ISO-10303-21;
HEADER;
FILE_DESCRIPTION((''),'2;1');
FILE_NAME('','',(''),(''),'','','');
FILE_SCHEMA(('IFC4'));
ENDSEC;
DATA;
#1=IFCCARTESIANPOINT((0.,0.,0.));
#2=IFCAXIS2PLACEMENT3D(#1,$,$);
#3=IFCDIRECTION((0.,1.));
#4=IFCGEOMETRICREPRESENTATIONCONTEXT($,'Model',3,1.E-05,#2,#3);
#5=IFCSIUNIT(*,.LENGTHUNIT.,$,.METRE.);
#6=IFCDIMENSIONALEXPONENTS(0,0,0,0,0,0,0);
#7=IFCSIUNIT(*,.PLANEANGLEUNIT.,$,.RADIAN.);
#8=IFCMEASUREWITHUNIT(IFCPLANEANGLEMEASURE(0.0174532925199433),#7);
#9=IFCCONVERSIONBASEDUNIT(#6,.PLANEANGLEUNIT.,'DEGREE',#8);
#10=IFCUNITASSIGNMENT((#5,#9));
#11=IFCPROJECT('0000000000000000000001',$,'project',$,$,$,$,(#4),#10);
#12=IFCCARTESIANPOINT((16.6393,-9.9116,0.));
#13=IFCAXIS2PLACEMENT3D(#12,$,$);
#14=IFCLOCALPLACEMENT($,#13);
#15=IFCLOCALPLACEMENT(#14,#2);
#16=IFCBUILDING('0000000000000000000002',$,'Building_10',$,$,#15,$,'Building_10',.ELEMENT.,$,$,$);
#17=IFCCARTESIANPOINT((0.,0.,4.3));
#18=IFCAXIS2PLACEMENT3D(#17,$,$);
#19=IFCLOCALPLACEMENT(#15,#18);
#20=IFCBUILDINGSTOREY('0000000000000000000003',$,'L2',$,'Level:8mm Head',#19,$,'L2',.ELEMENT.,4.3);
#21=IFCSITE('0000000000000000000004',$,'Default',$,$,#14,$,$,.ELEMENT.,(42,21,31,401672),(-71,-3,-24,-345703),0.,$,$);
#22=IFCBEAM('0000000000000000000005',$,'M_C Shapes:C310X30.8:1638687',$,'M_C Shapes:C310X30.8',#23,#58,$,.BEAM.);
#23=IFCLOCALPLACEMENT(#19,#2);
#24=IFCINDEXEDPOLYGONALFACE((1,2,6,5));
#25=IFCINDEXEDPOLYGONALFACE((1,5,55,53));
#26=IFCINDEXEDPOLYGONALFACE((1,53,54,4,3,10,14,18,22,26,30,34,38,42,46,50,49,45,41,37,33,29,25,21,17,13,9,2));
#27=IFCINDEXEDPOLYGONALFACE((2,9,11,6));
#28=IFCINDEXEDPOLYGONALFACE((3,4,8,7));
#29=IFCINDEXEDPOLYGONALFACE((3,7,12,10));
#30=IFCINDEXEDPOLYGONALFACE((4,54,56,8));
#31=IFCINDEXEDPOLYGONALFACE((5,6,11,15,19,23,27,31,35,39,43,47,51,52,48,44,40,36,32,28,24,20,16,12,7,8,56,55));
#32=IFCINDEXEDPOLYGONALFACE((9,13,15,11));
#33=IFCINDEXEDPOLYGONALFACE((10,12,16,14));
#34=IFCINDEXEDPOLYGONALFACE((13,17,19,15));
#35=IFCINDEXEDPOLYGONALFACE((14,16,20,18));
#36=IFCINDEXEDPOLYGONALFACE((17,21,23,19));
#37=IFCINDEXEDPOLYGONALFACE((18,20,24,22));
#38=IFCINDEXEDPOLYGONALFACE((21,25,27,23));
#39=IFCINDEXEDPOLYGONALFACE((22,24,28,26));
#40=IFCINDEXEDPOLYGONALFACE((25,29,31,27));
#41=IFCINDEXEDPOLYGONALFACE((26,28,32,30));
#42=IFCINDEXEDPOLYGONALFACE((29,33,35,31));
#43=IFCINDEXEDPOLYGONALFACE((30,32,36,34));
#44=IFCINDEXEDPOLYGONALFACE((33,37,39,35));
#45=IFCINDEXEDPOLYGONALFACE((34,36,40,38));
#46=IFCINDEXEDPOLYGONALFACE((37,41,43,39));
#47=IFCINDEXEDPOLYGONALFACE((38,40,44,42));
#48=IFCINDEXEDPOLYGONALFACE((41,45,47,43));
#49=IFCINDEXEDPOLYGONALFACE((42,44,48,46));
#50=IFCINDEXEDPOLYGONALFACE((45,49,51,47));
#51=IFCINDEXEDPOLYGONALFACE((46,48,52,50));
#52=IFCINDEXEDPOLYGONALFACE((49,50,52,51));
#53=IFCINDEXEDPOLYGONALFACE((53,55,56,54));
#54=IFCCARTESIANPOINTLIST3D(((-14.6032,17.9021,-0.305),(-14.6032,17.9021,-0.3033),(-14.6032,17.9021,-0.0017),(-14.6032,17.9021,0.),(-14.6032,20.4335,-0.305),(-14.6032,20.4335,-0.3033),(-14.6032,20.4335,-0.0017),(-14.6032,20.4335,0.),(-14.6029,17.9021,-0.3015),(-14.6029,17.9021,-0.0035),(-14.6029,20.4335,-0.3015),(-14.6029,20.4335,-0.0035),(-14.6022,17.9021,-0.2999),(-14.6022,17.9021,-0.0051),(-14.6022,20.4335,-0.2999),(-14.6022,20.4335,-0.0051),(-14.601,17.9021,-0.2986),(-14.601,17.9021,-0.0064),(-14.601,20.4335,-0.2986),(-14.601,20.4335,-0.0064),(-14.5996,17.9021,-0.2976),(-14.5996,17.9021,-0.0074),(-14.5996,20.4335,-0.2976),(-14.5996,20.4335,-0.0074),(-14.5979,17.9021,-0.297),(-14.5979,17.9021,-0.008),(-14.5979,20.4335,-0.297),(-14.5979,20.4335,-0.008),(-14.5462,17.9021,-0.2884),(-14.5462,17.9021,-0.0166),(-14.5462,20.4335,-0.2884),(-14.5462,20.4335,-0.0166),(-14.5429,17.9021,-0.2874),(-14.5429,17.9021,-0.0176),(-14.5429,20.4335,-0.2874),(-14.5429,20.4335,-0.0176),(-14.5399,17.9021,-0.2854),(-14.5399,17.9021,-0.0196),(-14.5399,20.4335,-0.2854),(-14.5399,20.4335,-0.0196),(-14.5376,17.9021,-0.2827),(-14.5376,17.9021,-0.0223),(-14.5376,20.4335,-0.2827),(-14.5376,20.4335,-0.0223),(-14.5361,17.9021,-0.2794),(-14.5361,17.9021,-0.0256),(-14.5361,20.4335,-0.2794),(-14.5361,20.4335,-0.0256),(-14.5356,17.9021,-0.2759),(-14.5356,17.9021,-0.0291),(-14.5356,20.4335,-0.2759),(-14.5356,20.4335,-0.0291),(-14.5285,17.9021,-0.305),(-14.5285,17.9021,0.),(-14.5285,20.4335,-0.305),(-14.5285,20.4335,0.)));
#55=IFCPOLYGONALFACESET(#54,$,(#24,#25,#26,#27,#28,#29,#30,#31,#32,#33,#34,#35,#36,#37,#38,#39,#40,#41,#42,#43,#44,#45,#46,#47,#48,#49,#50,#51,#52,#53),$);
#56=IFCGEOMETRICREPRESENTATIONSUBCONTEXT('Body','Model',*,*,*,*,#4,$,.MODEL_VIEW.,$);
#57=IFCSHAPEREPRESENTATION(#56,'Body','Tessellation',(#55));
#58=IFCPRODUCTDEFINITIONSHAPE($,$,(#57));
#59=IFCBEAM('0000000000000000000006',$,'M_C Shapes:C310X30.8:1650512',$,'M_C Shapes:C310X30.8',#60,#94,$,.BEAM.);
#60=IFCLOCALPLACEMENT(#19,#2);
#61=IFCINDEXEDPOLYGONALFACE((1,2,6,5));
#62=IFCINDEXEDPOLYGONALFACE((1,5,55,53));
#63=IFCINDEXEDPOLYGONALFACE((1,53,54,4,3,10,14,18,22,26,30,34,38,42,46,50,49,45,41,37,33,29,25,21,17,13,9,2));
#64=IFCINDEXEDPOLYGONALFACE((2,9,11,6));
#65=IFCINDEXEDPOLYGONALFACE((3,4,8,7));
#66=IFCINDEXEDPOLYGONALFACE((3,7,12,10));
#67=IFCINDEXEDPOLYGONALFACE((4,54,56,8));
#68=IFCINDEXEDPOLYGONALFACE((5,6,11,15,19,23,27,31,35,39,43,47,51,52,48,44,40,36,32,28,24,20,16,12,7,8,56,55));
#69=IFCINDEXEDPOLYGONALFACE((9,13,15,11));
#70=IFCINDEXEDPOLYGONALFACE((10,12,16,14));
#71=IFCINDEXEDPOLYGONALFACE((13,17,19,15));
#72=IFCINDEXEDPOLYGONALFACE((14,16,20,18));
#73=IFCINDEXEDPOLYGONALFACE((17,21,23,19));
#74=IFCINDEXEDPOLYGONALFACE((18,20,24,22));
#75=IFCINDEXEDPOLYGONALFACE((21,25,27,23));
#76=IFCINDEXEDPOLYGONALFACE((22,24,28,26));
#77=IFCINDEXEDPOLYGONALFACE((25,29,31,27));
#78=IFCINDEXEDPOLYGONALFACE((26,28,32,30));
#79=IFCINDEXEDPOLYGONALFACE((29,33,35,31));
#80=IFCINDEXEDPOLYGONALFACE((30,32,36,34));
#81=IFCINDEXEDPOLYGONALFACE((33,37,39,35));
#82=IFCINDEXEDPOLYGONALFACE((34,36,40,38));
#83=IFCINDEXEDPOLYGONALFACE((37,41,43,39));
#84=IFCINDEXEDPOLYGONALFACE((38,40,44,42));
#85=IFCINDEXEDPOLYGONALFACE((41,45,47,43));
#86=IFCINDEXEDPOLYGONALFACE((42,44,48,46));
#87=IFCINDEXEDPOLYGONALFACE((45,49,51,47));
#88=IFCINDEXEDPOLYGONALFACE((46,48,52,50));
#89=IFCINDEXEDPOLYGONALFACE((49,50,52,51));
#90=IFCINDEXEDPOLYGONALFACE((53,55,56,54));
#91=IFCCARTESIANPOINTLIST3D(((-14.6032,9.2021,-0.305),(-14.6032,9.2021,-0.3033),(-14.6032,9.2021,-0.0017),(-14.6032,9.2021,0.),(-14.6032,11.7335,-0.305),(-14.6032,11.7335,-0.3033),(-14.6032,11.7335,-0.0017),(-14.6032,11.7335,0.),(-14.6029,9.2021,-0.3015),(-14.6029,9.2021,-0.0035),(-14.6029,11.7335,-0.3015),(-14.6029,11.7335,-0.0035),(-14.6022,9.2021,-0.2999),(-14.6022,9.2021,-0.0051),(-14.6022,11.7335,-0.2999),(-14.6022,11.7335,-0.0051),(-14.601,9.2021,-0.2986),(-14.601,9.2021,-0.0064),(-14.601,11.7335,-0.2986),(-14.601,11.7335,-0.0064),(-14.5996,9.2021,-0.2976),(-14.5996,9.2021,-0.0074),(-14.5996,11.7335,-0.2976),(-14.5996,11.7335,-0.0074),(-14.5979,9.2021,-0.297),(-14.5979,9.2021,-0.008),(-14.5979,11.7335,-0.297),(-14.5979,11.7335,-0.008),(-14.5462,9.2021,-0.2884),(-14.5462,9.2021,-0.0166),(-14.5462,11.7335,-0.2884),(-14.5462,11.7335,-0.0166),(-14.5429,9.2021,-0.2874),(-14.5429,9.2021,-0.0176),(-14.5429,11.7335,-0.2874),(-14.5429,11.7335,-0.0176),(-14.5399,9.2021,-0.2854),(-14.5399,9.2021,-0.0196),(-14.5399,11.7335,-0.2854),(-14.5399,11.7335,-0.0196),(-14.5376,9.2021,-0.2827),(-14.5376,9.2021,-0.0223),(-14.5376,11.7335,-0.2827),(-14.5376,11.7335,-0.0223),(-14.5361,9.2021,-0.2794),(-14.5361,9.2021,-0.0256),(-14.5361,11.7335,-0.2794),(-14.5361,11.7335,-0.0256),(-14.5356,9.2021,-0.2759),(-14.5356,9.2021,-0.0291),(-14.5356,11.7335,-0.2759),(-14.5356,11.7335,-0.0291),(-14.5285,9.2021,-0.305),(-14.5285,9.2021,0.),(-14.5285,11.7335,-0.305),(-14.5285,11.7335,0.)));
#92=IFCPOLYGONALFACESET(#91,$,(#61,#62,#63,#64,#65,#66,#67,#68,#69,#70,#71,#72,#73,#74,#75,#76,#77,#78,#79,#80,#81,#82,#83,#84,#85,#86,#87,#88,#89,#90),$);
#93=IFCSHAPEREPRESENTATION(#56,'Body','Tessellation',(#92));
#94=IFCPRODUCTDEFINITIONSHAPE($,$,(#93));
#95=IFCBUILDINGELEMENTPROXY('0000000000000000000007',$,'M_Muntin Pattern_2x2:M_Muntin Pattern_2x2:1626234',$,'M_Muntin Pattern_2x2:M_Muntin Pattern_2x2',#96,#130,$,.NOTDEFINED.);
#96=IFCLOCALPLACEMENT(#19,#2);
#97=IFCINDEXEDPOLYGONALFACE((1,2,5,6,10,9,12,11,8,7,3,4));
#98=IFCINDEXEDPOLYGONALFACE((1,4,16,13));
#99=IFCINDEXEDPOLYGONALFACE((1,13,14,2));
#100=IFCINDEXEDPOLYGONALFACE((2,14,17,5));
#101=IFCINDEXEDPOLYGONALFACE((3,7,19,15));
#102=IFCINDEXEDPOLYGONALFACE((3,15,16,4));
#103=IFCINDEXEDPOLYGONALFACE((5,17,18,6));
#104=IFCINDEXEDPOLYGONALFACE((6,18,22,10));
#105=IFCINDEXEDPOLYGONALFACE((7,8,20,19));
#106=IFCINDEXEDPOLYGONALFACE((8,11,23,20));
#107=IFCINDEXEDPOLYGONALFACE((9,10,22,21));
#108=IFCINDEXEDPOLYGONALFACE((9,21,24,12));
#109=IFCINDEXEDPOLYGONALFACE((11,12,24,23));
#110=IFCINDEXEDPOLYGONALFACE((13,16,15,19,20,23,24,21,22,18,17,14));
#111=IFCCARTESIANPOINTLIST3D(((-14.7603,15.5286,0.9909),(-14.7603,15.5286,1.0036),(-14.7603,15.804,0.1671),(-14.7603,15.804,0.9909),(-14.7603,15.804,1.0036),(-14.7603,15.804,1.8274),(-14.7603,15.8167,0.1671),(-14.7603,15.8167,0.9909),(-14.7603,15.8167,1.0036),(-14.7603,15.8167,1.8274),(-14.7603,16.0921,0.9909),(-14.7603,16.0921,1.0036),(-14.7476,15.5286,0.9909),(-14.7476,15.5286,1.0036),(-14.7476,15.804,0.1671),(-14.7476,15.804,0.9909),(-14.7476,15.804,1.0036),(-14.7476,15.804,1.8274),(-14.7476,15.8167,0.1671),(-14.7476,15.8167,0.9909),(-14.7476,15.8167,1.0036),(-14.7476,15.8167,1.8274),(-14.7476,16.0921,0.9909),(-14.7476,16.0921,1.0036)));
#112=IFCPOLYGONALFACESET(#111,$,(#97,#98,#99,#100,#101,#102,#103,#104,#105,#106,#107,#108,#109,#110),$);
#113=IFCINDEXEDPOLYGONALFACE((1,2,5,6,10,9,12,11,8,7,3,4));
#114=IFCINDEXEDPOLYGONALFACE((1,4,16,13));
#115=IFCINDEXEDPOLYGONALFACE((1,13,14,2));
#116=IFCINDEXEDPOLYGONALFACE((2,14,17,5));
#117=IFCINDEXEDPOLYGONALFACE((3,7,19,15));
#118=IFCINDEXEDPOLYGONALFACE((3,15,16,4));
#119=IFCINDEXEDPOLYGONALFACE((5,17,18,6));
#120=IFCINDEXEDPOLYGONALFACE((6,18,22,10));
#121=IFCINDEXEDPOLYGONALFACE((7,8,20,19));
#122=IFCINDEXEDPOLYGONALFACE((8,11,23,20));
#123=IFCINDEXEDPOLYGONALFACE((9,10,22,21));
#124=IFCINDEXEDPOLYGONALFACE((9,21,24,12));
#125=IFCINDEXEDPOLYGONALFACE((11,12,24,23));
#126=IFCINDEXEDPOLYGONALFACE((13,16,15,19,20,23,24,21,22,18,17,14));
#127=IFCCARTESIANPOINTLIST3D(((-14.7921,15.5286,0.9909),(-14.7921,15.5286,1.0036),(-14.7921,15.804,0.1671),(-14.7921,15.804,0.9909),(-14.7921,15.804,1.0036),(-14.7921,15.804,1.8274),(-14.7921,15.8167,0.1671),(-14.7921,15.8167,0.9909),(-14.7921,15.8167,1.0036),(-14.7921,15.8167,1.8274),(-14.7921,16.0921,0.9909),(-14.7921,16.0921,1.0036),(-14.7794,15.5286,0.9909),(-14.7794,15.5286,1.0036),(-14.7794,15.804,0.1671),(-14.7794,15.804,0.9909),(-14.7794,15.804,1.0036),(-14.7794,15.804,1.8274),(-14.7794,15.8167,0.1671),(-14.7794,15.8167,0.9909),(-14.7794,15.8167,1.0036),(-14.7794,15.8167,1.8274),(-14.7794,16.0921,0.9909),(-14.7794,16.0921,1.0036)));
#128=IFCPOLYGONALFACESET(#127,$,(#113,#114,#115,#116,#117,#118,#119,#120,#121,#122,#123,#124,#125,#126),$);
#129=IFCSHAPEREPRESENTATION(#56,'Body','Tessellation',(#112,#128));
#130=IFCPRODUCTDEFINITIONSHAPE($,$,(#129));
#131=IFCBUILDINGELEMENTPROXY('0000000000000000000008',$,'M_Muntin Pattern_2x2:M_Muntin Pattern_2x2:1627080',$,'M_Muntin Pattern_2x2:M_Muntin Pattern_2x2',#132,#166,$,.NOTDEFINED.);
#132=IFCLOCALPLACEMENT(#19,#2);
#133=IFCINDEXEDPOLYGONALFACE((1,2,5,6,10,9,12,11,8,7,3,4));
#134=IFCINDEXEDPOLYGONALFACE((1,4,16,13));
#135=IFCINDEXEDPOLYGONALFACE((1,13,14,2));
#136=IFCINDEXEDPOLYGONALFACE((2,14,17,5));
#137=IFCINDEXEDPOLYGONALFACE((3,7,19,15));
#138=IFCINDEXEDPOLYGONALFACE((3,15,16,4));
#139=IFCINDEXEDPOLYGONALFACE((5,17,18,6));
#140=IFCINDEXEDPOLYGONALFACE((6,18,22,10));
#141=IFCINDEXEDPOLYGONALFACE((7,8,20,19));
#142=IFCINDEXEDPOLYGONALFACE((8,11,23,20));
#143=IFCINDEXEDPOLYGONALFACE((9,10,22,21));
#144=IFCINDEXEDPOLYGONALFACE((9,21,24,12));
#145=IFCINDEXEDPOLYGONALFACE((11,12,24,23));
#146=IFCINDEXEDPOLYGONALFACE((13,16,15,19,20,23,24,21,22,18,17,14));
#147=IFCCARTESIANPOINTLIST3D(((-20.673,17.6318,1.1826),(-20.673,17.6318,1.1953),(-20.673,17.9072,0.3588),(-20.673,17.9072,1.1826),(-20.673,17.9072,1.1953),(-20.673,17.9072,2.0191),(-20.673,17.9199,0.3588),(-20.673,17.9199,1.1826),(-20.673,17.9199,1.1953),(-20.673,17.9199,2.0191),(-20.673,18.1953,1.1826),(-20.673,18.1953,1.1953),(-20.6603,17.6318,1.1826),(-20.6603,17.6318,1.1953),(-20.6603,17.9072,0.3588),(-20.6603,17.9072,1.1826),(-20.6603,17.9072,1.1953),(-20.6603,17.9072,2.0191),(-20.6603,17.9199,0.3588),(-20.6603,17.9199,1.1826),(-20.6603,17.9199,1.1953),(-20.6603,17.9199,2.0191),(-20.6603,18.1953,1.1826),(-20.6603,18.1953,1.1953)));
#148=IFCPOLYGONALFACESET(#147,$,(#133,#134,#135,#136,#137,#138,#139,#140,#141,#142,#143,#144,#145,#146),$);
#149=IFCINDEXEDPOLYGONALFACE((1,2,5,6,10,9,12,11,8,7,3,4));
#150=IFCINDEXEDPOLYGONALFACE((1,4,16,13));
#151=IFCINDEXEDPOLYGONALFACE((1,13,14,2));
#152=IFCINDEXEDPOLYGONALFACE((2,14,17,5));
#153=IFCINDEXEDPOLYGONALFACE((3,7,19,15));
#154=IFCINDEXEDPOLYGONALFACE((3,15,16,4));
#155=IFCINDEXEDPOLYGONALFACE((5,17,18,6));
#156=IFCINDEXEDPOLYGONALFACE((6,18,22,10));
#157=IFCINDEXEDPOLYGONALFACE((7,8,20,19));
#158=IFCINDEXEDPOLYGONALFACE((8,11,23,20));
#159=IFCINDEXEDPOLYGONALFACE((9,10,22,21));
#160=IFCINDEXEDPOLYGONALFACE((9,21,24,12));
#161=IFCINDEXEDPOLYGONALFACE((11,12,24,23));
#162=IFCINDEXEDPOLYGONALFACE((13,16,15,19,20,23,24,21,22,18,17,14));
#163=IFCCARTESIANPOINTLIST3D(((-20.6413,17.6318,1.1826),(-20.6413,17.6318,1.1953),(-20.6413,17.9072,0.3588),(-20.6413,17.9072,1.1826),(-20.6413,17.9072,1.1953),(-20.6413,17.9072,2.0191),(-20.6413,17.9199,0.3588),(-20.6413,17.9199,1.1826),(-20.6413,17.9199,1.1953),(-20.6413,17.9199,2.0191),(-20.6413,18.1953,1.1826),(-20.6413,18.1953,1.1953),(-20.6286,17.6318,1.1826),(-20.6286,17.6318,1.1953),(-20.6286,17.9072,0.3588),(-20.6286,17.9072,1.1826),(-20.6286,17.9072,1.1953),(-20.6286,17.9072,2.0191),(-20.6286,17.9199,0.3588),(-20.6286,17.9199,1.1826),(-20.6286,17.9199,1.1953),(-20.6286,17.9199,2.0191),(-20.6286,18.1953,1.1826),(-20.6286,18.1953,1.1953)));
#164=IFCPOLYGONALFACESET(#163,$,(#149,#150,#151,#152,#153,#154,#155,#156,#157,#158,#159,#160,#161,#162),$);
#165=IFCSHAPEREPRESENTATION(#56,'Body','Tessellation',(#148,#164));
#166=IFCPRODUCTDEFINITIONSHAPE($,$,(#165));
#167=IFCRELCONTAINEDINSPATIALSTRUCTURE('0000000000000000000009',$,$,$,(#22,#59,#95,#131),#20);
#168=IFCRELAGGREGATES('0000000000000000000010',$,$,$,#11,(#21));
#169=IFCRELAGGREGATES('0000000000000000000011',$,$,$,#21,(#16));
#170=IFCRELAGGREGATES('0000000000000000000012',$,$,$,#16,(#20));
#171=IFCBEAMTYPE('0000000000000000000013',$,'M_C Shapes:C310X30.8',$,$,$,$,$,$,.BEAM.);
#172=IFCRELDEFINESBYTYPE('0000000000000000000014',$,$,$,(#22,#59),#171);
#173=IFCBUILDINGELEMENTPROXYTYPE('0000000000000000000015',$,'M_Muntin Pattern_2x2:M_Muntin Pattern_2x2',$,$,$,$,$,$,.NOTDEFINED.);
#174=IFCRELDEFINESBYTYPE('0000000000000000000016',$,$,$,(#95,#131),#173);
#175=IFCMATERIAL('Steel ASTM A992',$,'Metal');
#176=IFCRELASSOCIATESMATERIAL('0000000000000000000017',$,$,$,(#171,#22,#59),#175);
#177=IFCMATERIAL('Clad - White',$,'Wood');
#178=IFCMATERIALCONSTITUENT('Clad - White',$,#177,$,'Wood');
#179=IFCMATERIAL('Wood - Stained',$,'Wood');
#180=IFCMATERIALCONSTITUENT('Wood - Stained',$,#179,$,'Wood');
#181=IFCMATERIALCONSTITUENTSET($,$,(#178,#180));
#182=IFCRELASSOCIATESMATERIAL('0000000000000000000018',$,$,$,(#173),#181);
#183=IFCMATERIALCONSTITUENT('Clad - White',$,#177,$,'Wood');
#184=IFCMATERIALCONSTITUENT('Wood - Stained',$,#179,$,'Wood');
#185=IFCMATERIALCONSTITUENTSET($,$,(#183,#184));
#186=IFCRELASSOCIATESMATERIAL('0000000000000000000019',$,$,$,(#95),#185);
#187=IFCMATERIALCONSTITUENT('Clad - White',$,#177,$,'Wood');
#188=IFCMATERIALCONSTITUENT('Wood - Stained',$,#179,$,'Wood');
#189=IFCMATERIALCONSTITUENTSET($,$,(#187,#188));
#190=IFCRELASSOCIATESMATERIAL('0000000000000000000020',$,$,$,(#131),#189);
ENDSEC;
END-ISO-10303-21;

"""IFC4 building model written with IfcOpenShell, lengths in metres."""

from ifc_helpers import new_model, entity, si_unit, converted_unit, direction, frame, origin, place, context, subcontext, project, spatial, line, arc, indexed_curve, outline, extrude, source, transform, mapped, material, constituent, constituent_set, type_object, type_shapes, element, save


model = new_model("IFC4")

# Units and contexts
model_context = context("Model", 3, precision=1e-05, world=origin(), true_north=direction((0.0, 1.0)))
body_context = subcontext(model_context, "Body", "Model", "MODEL_VIEW")
ifc_project = project(units=[si_unit("LENGTHUNIT", "METRE"), converted_unit("PLANEANGLEUNIT", "DEGREE", entity("IfcPlaneAngleMeasure", 0.0174532925199433), si_unit("PLANEANGLEUNIT", "RADIAN"), dimensions=[0, 0, 0, 0, 0, 0, 0])], contexts=[model_context])

# Site, building, storey
site_placement = place(None, frame((16.6393, -9.9116, 0.0)))
site = spatial("IfcSite", under=ifc_project, at=site_placement, Name="Default", CompositionType="ELEMENT", RefLatitude=(42, 21, 31, 401672), RefLongitude=(-71, -3, -24, -345703), RefElevation=0.0)
building_placement = place(site_placement, origin())
building = spatial("IfcBuilding", under=site, at=building_placement, Name="Building_10", LongName="Building_10", CompositionType="ELEMENT")
storey_placement = place(building_placement, frame((0.0, 0.0, 4.3)))
storey = spatial("IfcBuildingStorey", under=building, at=storey_placement, Name="L2", ObjectType="Level:8mm Head", LongName="L2", CompositionType="ELEMENT", Elevation=4.3)

# Shared definitions
ifc_material_1 = material(Name="Steel ASTM A992", Category="Metal")

# Beams
beam_type_1 = type_object("IfcBeamType", Name="M_C Shapes:C310X30.8", PredefinedType="BEAM", material=ifc_material_1)
shared_shape_1 = source(origin(), body_context, "Body", "SweptSolid", [
    extrude(outline(indexed_curve([(-0.0406, -0.1525), (0.0341, -0.1525), (0.0341, -0.1508), (0.0326, -0.1467), (0.0288, -0.1445), (-0.0228, -0.1359), (-0.0305, -0.1316), (-0.0335, -0.1234), (-0.0335, 0.1234), (-0.0305, 0.1316), (-0.0228, 0.1359), (0.0288, 0.1445), (0.0326, 0.1467), (0.0341, 0.1508), (0.0341, 0.1525), (-0.0406, 0.1525)], segments=[line(1, 2, 3), arc(3, 4, 5), line(5, 6), arc(6, 7, 8), line(8, 9), arc(9, 10, 11), line(11, 12), arc(12, 13, 14), line(14, 15, 16, 1)], self_intersect=False)), frame((-1.2657, -0.0229, 0.0), z_axis=(1.0, 0.0, 0.0), x_axis=(0.0, -1.0, 0.0)), (0.0, 0.0, 1.0), 2.5314),
])
type_shapes(beam_type_1, [shared_shape_1])
for number, where, z_axis, x_axis, name in (
    (1, (-14.5462, 19.1678, -0.1525), (0.0, 0.0, 1.0), (0.0, -1.0, 0.0), "M_C Shapes:C310X30.8:1638687"),
    (2, (-14.5462, 10.4678, -0.1525), (0.0, 0.0, 1.0), (0.0, -1.0, 0.0), "M_C Shapes:C310X30.8:1650512"),
):
    element("IfcBeam", number, at=place(storey_placement, frame(where, z_axis=z_axis, x_axis=x_axis)), inside=storey, type_object=beam_type_1, material=ifc_material_1, Name=name, ObjectType="M_C Shapes:C310X30.8", PredefinedType="BEAM", context=body_context, shape_type="MappedRepresentation", body=[
        mapped(shared_shape_1, transform((0.0, 0.0, 0.0), scale=1.0)),
    ])

# Building element proxies
ifc_material_2 = material(Name="Clad - White", Category="Wood")
ifc_constituent_1 = constituent(ifc_material_2, Name="Clad - White", Category="Wood")
ifc_material_3 = material(Name="Wood - Stained", Category="Wood")
ifc_constituent_2 = constituent(ifc_material_3, Name="Wood - Stained", Category="Wood")
ifc_constituent_set_1 = constituent_set(constituents=[ifc_constituent_1, ifc_constituent_2])
ifc_constituent_3 = constituent(ifc_material_2, Name="Clad - White", Category="Wood")
ifc_constituent_4 = constituent(ifc_material_3, Name="Wood - Stained", Category="Wood")
ifc_constituent_set_2 = constituent_set(constituents=[ifc_constituent_3, ifc_constituent_4])
building_element_proxy_type_1 = type_object("IfcBuildingElementProxyType", Name="M_Muntin Pattern_2x2:M_Muntin Pattern_2x2", PredefinedType="NOTDEFINED", material=ifc_constituent_set_2)
shared_shape_2 = source(origin(), body_context, "Body", "SweptSolid", [
    extrude(outline(indexed_curve([(0.0064, -0.0064), (0.8301, -0.0064), (0.8301, 0.0063), (0.0064, 0.0063), (0.0064, 0.2817), (-0.0063, 0.2817), (-0.0063, 0.0063), (-0.8302, 0.0063), (-0.8302, -0.0064), (-0.0063, -0.0064), (-0.0063, -0.2817), (0.0064, -0.2817), (0.0064, -0.0064)], self_intersect=False)), frame((0.0, 0.0095, 0.8301), z_axis=(0.0, 1.0, 0.0), x_axis=(0.0, 0.0, 1.0)), (0.0, 0.0, 1.0), 0.0127),
    extrude(outline(indexed_curve([(0.0064, -0.0064), (0.8302, -0.0064), (0.8302, 0.0063), (0.0064, 0.0063), (0.0064, 0.2817), (-0.0063, 0.2817), (-0.0063, 0.0063), (-0.8302, 0.0063), (-0.8302, -0.0064), (-0.0063, -0.0064), (-0.0063, -0.2817), (0.0064, -0.2817), (0.0064, -0.0064)], self_intersect=False)), frame((0.0, -0.0222, 0.8302), z_axis=(0.0, 1.0, 0.0), x_axis=(0.0, 0.0, 1.0)), (0.0, 0.0, 1.0), 0.0127),
])
type_shapes(building_element_proxy_type_1, [shared_shape_2])
proxy_1_placement = place(storey_placement, frame((-14.7698, 15.8104, 0.1671), z_axis=(0.0, 0.0, 1.0), x_axis=(0.0, -1.0, 0.0)))
element("IfcBuildingElementProxy", 3, at=proxy_1_placement, inside=storey, type_object=building_element_proxy_type_1, material=ifc_constituent_set_1, Name="M_Muntin Pattern_2x2:M_Muntin Pattern_2x2:1626234", ObjectType="M_Muntin Pattern_2x2:M_Muntin Pattern_2x2", PredefinedType="NOTDEFINED", context=body_context, shape_type="MappedRepresentation", body=[
    mapped(shared_shape_2, transform((0.0, 0.0, 0.0), scale=1.0)),
])
ifc_constituent_5 = constituent(ifc_material_2, Name="Clad - White", Category="Wood")
ifc_constituent_6 = constituent(ifc_material_3, Name="Wood - Stained", Category="Wood")
ifc_constituent_set_3 = constituent_set(constituents=[ifc_constituent_5, ifc_constituent_6])
proxy_2_placement = place(storey_placement, frame((-20.6508, 17.9136, 0.3588), z_axis=(0.0, 0.0, 1.0), x_axis=(0.0, 1.0, 0.0)))
element("IfcBuildingElementProxy", 4, at=proxy_2_placement, inside=storey, type_object=building_element_proxy_type_1, material=ifc_constituent_set_3, Name="M_Muntin Pattern_2x2:M_Muntin Pattern_2x2:1627080", ObjectType="M_Muntin Pattern_2x2:M_Muntin Pattern_2x2", PredefinedType="NOTDEFINED", context=body_context, shape_type="MappedRepresentation", body=[
    mapped(shared_shape_2, transform((0.0, 0.0, 0.0), scale=1.0)),
])

save(model, "model.ifc")
